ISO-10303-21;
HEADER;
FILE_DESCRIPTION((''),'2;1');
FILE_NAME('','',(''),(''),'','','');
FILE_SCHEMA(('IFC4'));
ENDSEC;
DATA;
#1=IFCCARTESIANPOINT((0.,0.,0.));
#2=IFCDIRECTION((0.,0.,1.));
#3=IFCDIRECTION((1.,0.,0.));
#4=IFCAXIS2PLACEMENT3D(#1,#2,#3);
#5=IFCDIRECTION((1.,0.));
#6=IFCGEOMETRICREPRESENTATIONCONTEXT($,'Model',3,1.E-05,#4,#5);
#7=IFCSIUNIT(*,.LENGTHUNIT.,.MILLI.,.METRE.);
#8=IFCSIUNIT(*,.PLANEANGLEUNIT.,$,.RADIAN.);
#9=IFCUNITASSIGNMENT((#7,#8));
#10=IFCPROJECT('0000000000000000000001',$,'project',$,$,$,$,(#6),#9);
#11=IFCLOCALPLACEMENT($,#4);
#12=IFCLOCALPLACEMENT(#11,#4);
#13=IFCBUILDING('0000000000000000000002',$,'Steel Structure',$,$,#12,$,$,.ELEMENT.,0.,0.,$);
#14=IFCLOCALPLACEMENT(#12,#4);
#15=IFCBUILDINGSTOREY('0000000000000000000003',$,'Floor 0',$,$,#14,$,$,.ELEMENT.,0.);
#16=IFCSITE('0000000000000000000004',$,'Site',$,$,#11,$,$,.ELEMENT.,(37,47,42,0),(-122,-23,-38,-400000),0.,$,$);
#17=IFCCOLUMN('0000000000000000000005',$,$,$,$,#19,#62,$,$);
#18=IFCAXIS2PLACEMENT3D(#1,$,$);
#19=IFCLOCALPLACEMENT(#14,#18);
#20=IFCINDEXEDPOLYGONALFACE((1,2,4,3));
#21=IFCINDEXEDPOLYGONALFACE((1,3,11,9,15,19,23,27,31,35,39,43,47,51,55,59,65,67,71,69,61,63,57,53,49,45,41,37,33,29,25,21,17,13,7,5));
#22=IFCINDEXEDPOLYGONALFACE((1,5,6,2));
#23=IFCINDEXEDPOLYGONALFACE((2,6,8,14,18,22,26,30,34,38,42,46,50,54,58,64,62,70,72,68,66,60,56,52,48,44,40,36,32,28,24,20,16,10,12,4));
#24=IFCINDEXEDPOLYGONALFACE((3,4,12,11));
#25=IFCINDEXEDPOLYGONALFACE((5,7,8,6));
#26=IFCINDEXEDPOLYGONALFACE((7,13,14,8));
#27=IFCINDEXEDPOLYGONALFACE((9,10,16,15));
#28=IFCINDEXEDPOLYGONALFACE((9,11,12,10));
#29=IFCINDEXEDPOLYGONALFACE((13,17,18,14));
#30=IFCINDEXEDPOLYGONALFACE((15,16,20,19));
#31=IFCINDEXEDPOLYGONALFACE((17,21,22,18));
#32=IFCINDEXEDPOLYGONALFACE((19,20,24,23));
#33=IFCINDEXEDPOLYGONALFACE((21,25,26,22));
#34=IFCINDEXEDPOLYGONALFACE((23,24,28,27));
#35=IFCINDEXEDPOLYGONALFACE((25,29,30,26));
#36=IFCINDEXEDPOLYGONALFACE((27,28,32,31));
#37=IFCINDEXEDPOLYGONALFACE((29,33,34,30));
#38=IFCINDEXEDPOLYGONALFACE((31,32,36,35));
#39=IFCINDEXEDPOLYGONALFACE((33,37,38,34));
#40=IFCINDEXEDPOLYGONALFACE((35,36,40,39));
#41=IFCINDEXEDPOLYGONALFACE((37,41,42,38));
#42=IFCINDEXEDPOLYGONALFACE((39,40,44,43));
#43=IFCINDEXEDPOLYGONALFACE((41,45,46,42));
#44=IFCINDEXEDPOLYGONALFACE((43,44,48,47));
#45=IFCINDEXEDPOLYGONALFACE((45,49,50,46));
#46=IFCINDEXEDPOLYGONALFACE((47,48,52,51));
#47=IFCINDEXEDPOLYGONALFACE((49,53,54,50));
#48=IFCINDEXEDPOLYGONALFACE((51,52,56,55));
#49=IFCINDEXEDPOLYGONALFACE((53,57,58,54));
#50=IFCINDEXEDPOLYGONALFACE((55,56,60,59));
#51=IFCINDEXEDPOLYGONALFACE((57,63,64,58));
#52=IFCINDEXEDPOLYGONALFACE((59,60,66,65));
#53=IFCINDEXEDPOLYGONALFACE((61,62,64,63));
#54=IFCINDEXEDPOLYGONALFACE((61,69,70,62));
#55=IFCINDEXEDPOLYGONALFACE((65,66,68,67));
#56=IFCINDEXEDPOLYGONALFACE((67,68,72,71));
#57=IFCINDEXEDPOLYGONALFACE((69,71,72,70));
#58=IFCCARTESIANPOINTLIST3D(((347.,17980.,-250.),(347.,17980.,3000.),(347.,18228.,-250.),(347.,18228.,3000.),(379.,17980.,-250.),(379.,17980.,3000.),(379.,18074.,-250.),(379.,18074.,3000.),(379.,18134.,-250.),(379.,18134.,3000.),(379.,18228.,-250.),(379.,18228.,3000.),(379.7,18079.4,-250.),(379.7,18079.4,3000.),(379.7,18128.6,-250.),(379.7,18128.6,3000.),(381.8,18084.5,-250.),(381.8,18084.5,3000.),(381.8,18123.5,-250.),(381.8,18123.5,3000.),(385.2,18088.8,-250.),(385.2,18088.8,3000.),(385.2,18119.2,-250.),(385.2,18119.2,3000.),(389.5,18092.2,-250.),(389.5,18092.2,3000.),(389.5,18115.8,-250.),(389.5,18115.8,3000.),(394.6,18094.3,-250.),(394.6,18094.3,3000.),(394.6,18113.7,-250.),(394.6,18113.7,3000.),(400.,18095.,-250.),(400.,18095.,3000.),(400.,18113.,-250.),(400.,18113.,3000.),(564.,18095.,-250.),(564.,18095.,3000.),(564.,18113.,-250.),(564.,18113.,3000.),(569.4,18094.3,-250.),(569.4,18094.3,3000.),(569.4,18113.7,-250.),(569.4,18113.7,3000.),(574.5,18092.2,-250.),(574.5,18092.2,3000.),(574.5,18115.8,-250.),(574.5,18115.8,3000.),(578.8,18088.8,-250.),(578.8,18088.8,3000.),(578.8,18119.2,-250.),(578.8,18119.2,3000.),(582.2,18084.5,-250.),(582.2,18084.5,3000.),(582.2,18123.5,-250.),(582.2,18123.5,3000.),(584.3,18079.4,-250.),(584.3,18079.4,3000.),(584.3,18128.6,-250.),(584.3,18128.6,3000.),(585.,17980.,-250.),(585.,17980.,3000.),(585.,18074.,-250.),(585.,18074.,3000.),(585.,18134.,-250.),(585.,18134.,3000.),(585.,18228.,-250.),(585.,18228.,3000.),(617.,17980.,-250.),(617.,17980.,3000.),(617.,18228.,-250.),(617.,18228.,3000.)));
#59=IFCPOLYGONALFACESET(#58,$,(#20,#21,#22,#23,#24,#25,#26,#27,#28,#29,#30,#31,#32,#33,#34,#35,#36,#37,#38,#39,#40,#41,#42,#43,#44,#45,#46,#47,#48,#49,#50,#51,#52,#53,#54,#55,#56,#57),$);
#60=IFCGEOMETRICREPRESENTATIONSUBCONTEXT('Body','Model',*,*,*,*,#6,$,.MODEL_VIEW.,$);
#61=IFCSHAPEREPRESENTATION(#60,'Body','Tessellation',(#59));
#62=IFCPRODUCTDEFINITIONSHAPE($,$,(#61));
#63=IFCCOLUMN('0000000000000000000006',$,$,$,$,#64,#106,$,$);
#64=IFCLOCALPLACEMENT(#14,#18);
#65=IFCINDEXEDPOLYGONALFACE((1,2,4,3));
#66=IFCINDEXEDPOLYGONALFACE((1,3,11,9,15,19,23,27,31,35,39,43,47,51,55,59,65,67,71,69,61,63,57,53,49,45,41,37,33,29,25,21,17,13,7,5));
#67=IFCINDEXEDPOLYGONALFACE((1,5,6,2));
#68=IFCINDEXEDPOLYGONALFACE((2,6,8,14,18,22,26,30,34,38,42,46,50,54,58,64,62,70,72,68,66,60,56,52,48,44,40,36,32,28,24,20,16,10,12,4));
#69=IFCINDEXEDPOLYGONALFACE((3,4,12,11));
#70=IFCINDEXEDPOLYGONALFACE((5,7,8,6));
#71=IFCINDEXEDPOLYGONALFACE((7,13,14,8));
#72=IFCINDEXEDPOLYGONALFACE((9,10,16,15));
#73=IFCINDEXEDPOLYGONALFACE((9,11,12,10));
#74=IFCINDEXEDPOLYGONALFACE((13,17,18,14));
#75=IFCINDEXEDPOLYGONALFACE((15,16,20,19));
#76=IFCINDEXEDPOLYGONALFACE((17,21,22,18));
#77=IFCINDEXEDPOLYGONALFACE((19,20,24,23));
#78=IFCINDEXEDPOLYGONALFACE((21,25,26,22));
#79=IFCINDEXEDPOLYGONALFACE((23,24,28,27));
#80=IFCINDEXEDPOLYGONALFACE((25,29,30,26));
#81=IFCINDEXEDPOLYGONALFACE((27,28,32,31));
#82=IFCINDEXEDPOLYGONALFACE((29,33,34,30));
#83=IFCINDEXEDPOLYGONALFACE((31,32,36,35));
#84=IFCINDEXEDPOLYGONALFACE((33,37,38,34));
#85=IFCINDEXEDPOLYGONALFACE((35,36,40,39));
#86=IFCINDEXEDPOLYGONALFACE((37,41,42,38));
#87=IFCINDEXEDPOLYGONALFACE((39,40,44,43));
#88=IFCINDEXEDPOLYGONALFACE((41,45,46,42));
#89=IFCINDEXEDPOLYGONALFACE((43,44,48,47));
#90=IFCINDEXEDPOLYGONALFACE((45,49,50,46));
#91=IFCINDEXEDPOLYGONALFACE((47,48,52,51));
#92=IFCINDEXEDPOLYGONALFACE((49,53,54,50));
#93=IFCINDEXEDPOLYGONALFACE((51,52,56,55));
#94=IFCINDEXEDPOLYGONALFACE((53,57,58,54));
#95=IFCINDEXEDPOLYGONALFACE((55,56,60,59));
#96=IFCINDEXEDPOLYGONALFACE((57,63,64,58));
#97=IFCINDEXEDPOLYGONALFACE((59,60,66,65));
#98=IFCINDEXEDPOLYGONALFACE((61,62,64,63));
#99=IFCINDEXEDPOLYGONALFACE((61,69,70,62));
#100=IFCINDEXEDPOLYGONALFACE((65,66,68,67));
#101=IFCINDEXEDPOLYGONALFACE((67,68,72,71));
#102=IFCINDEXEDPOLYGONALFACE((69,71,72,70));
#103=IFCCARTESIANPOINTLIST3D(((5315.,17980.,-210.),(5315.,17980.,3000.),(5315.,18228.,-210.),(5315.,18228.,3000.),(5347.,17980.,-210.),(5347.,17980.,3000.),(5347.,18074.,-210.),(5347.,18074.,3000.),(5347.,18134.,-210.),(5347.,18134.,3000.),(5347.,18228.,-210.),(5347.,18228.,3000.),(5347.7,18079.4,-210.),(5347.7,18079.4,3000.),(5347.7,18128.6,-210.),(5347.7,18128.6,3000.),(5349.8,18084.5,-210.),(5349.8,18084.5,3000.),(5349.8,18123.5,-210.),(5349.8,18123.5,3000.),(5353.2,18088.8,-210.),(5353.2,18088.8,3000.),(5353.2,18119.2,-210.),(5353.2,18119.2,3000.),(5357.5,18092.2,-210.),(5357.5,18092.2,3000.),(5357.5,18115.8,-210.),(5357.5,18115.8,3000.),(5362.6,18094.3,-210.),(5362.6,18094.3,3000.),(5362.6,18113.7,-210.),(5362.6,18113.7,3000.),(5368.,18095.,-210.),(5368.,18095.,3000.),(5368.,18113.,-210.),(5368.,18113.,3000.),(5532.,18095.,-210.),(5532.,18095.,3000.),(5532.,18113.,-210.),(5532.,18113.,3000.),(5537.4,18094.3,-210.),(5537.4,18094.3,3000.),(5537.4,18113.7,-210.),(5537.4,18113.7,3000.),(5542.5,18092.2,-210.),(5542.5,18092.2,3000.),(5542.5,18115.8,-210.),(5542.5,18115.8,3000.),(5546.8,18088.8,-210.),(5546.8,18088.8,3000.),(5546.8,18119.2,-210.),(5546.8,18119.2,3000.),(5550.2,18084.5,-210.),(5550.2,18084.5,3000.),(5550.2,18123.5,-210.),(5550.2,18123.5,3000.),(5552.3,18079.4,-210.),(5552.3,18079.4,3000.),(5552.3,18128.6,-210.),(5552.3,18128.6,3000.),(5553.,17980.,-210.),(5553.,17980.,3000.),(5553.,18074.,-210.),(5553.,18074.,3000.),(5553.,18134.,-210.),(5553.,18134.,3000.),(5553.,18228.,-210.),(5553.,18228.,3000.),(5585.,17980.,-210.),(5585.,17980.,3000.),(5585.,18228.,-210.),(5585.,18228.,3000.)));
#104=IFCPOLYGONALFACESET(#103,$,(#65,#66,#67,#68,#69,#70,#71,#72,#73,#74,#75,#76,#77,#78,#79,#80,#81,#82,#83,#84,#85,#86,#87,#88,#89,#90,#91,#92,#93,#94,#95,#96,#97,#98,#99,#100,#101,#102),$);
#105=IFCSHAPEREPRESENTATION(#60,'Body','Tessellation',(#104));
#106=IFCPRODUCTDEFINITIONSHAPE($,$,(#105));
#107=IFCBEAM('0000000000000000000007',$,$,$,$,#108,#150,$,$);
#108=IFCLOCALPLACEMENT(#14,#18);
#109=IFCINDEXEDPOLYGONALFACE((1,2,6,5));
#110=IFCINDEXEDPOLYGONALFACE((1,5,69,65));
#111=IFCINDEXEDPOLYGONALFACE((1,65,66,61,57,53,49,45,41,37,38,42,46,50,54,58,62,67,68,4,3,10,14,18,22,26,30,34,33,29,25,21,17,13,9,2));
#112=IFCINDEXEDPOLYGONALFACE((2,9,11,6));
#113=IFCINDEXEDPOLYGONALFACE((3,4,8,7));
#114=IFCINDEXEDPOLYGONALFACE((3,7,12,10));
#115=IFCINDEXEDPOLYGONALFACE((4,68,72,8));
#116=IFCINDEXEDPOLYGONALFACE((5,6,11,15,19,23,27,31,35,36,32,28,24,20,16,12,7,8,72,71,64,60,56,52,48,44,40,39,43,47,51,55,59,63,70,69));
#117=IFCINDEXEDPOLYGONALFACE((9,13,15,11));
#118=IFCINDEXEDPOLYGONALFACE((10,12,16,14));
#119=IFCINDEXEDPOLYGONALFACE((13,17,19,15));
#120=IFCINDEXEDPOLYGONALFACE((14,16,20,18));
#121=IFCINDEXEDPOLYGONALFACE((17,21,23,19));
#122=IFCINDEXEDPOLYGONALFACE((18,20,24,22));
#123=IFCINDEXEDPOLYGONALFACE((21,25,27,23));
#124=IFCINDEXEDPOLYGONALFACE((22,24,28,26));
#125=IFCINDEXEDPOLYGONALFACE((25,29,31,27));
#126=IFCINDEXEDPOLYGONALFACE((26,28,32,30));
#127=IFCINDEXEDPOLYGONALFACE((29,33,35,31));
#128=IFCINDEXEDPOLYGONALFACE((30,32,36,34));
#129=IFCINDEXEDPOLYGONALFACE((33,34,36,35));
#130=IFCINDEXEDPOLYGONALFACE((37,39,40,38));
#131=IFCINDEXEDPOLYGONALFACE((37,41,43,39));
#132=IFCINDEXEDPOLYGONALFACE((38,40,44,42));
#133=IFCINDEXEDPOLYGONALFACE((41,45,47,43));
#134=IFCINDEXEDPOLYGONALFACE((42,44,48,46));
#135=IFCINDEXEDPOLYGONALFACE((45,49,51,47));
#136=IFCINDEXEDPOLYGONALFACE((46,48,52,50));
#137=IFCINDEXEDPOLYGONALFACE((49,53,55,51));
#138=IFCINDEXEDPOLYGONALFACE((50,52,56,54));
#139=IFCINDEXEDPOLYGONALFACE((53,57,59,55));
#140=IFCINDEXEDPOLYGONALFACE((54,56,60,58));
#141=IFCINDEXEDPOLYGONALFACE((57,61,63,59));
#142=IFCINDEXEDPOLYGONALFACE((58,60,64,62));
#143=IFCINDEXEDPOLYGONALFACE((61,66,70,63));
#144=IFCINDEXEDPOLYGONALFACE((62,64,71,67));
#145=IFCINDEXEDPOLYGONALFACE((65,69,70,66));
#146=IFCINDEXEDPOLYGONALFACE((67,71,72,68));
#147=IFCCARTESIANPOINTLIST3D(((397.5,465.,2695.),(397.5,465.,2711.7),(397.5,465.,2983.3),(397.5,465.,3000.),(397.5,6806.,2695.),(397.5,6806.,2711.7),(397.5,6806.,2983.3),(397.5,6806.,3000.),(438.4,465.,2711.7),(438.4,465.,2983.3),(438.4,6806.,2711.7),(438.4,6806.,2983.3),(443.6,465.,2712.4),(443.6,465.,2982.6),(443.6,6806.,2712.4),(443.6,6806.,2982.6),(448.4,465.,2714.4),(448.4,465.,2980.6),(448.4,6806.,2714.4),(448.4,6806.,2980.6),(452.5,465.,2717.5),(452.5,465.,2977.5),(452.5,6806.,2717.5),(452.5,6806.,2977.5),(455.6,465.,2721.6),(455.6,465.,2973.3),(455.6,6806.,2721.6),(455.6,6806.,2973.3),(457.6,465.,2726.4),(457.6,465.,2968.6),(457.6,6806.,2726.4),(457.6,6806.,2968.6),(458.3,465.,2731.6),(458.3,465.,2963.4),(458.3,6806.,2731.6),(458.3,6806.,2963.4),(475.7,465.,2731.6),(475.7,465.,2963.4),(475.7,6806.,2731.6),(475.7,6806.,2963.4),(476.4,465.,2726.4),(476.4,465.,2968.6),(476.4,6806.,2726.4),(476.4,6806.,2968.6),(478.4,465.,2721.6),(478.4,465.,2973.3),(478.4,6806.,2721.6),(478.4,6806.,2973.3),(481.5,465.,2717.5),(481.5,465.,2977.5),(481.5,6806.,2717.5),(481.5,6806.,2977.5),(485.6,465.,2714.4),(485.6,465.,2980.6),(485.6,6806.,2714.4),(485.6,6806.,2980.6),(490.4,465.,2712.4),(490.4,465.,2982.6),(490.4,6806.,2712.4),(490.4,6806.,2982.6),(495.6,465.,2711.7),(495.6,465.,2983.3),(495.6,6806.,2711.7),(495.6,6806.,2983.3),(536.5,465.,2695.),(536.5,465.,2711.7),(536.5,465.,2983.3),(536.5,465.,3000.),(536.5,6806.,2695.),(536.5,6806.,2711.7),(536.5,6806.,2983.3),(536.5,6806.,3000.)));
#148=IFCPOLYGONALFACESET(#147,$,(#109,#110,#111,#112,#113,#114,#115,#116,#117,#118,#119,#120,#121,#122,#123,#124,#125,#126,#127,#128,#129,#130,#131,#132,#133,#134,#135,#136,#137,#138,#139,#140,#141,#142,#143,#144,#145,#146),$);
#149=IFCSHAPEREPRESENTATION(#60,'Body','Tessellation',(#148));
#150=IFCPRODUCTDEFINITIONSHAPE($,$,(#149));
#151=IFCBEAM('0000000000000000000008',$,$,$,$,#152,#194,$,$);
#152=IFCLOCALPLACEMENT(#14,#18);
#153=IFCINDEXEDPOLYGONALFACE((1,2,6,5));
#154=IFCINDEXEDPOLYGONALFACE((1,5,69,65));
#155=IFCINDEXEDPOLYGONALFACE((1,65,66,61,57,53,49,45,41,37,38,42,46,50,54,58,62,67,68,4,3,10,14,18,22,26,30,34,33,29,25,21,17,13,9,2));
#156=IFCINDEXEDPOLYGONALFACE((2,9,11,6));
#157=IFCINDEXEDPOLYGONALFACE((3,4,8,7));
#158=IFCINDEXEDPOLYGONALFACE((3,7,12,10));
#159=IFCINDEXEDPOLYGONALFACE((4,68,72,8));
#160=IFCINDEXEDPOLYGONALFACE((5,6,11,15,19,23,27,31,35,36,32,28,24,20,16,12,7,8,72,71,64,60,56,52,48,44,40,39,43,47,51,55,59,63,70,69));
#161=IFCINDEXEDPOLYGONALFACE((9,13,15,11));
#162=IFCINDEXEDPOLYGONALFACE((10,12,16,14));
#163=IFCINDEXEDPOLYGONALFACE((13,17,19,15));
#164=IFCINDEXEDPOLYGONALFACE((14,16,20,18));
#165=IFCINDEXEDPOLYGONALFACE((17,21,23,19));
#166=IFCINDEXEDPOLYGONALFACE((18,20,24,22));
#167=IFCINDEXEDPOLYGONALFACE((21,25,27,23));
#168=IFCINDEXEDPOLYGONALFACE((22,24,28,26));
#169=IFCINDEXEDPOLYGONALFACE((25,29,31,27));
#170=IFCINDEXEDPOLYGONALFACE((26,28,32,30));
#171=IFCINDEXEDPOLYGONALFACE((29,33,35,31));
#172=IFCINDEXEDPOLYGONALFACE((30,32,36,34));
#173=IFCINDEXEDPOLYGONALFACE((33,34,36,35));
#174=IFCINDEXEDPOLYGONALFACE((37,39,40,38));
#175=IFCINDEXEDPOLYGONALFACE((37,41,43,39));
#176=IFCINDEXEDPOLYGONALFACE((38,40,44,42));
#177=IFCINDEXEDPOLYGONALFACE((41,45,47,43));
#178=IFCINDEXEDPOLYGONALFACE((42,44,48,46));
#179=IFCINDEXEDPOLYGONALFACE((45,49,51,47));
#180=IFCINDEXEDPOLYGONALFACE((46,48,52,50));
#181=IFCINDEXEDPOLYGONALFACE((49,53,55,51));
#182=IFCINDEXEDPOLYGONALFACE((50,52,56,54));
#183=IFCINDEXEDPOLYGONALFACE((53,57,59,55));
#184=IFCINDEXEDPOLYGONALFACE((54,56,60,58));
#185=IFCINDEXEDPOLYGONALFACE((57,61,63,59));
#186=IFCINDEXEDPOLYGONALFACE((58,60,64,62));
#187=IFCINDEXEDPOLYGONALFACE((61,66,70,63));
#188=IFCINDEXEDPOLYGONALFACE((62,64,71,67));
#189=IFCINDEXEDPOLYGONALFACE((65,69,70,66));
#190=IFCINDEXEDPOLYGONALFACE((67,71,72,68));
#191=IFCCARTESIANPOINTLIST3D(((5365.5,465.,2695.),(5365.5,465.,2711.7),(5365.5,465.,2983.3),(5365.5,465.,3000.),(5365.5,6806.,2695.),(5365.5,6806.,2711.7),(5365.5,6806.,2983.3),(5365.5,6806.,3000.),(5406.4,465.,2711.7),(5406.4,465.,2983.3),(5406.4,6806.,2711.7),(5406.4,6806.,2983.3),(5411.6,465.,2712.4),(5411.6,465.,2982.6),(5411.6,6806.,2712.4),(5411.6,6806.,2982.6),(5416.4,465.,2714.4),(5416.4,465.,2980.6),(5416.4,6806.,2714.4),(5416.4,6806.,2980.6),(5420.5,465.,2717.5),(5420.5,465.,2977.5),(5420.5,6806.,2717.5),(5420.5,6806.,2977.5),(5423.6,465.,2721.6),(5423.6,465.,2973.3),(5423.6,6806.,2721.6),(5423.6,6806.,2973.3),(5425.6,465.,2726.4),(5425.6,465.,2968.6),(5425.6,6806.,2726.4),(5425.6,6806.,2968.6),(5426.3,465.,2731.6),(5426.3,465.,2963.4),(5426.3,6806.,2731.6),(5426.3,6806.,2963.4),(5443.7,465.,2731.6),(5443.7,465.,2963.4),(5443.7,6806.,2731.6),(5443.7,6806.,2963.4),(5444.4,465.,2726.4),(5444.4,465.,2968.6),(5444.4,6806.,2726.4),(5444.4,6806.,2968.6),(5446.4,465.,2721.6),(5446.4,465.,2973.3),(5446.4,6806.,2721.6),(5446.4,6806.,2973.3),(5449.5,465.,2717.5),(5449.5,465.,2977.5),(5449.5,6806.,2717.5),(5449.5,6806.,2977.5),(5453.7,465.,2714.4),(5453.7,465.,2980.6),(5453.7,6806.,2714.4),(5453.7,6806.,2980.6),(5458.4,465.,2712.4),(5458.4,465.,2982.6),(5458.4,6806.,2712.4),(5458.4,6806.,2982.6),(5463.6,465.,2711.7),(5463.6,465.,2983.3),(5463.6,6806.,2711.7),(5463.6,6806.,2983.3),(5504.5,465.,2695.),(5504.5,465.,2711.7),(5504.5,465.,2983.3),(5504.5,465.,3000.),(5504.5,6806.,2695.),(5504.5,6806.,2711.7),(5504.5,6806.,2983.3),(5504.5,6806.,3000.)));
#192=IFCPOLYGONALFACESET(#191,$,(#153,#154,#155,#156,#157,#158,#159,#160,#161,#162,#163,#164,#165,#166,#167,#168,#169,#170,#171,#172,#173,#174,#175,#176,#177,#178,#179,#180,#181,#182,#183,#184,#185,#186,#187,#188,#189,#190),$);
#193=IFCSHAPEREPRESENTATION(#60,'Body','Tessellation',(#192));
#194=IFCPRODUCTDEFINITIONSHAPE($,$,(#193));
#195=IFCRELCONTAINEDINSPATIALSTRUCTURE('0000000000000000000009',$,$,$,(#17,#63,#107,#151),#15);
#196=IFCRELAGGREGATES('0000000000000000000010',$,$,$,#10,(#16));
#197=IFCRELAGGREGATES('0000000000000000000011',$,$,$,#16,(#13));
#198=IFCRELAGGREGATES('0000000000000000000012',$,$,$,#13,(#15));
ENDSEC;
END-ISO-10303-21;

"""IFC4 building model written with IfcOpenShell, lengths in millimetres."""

from ifc_helpers import new_model, si_unit, direction, frame, origin_with_axes, origin_2d_with_axis, place, context, subcontext, project, spatial, i_section, extrude, element, save


model = new_model("IFC4")

# Units and contexts
model_context = context("Model", 3, precision=1e-05, world=origin_with_axes(), true_north=direction((1.0, 0.0)))
body_context = subcontext(model_context, "Body", "Model", "MODEL_VIEW")
ifc_project = project(units=[si_unit("LENGTHUNIT", "METRE", prefix="MILLI"), si_unit("PLANEANGLEUNIT", "RADIAN")], contexts=[model_context])

# Site, building, storey
site_placement = place(None, origin_with_axes())
site = spatial("IfcSite", under=ifc_project, at=site_placement, Name="Site", CompositionType="ELEMENT", RefLatitude=(37, 47, 42, 0), RefLongitude=(-122, -23, -38, -400000), RefElevation=0.0)
building_placement = place(site_placement, origin_with_axes())
building = spatial("IfcBuilding", under=site, at=building_placement, Name="Steel Structure", CompositionType="ELEMENT", ElevationOfRefHeight=0.0, ElevationOfTerrain=0.0)
storey_placement = place(building_placement, origin_with_axes())
storey = spatial("IfcBuildingStorey", under=building, at=storey_placement, Name="Floor 0", CompositionType="ELEMENT", Elevation=0.0)

# Columns
column_1_placement = place(storey_placement, frame((482.0, 18104.0, -250.0), z_axis=(0.0, 0.0, 1.0), x_axis=(0.0, 1.0, 0.0)))
element("IfcColumn", 1, at=column_1_placement, inside=storey, context=body_context, shape_type="SweptSolid", body=[
    extrude(i_section(OverallWidth=248.0, OverallDepth=270.0, WebThickness=18.0, FlangeThickness=32.0, FilletRadius=21.0, at=origin_2d_with_axis()), origin_with_axes(), (0.0, 0.0, 1.0), 3250.0),
])
column_2_placement = place(storey_placement, frame((5450.0, 18104.0, -210.0), z_axis=(0.0, 0.0, 1.0), x_axis=(0.0, -1.0, 0.0)))
element("IfcColumn", 2, at=column_2_placement, inside=storey, context=body_context, shape_type="SweptSolid", body=[
    extrude(i_section(OverallWidth=248.0, OverallDepth=270.0, WebThickness=18.0, FlangeThickness=32.0, FilletRadius=21.0, at=origin_2d_with_axis()), origin_with_axes(), (0.0, 0.0, 1.0), 3210.0),
])

# Beams
beam_1_placement = place(storey_placement, frame((467.0, 465.0, 2847.5), z_axis=(0.0, 1.0, 0.0), x_axis=(-1.0, 0.0, 0.0)))
element("IfcBeam", 3, at=beam_1_placement, inside=storey, context=body_context, shape_type="SweptSolid", body=[
    extrude(i_section(OverallWidth=139.0, OverallDepth=305.0, WebThickness=17.4, FlangeThickness=16.7, FilletRadius=19.9, at=origin_2d_with_axis()), origin_with_axes(), (0.0, 0.0, 1.0), 6341.0),
])
beam_2_placement = place(storey_placement, frame((5435.0, 465.0, 2847.5), z_axis=(0.0, 1.0, 0.0), x_axis=(-1.0, 0.0, 0.0)))
element("IfcBeam", 4, at=beam_2_placement, inside=storey, context=body_context, shape_type="SweptSolid", body=[
    extrude(i_section(OverallWidth=139.0, OverallDepth=305.0, WebThickness=17.4, FlangeThickness=16.7, FilletRadius=19.9, at=origin_2d_with_axis()), origin_with_axes(), (0.0, 0.0, 1.0), 6341.0),
])

save(model, "model.ifc")
